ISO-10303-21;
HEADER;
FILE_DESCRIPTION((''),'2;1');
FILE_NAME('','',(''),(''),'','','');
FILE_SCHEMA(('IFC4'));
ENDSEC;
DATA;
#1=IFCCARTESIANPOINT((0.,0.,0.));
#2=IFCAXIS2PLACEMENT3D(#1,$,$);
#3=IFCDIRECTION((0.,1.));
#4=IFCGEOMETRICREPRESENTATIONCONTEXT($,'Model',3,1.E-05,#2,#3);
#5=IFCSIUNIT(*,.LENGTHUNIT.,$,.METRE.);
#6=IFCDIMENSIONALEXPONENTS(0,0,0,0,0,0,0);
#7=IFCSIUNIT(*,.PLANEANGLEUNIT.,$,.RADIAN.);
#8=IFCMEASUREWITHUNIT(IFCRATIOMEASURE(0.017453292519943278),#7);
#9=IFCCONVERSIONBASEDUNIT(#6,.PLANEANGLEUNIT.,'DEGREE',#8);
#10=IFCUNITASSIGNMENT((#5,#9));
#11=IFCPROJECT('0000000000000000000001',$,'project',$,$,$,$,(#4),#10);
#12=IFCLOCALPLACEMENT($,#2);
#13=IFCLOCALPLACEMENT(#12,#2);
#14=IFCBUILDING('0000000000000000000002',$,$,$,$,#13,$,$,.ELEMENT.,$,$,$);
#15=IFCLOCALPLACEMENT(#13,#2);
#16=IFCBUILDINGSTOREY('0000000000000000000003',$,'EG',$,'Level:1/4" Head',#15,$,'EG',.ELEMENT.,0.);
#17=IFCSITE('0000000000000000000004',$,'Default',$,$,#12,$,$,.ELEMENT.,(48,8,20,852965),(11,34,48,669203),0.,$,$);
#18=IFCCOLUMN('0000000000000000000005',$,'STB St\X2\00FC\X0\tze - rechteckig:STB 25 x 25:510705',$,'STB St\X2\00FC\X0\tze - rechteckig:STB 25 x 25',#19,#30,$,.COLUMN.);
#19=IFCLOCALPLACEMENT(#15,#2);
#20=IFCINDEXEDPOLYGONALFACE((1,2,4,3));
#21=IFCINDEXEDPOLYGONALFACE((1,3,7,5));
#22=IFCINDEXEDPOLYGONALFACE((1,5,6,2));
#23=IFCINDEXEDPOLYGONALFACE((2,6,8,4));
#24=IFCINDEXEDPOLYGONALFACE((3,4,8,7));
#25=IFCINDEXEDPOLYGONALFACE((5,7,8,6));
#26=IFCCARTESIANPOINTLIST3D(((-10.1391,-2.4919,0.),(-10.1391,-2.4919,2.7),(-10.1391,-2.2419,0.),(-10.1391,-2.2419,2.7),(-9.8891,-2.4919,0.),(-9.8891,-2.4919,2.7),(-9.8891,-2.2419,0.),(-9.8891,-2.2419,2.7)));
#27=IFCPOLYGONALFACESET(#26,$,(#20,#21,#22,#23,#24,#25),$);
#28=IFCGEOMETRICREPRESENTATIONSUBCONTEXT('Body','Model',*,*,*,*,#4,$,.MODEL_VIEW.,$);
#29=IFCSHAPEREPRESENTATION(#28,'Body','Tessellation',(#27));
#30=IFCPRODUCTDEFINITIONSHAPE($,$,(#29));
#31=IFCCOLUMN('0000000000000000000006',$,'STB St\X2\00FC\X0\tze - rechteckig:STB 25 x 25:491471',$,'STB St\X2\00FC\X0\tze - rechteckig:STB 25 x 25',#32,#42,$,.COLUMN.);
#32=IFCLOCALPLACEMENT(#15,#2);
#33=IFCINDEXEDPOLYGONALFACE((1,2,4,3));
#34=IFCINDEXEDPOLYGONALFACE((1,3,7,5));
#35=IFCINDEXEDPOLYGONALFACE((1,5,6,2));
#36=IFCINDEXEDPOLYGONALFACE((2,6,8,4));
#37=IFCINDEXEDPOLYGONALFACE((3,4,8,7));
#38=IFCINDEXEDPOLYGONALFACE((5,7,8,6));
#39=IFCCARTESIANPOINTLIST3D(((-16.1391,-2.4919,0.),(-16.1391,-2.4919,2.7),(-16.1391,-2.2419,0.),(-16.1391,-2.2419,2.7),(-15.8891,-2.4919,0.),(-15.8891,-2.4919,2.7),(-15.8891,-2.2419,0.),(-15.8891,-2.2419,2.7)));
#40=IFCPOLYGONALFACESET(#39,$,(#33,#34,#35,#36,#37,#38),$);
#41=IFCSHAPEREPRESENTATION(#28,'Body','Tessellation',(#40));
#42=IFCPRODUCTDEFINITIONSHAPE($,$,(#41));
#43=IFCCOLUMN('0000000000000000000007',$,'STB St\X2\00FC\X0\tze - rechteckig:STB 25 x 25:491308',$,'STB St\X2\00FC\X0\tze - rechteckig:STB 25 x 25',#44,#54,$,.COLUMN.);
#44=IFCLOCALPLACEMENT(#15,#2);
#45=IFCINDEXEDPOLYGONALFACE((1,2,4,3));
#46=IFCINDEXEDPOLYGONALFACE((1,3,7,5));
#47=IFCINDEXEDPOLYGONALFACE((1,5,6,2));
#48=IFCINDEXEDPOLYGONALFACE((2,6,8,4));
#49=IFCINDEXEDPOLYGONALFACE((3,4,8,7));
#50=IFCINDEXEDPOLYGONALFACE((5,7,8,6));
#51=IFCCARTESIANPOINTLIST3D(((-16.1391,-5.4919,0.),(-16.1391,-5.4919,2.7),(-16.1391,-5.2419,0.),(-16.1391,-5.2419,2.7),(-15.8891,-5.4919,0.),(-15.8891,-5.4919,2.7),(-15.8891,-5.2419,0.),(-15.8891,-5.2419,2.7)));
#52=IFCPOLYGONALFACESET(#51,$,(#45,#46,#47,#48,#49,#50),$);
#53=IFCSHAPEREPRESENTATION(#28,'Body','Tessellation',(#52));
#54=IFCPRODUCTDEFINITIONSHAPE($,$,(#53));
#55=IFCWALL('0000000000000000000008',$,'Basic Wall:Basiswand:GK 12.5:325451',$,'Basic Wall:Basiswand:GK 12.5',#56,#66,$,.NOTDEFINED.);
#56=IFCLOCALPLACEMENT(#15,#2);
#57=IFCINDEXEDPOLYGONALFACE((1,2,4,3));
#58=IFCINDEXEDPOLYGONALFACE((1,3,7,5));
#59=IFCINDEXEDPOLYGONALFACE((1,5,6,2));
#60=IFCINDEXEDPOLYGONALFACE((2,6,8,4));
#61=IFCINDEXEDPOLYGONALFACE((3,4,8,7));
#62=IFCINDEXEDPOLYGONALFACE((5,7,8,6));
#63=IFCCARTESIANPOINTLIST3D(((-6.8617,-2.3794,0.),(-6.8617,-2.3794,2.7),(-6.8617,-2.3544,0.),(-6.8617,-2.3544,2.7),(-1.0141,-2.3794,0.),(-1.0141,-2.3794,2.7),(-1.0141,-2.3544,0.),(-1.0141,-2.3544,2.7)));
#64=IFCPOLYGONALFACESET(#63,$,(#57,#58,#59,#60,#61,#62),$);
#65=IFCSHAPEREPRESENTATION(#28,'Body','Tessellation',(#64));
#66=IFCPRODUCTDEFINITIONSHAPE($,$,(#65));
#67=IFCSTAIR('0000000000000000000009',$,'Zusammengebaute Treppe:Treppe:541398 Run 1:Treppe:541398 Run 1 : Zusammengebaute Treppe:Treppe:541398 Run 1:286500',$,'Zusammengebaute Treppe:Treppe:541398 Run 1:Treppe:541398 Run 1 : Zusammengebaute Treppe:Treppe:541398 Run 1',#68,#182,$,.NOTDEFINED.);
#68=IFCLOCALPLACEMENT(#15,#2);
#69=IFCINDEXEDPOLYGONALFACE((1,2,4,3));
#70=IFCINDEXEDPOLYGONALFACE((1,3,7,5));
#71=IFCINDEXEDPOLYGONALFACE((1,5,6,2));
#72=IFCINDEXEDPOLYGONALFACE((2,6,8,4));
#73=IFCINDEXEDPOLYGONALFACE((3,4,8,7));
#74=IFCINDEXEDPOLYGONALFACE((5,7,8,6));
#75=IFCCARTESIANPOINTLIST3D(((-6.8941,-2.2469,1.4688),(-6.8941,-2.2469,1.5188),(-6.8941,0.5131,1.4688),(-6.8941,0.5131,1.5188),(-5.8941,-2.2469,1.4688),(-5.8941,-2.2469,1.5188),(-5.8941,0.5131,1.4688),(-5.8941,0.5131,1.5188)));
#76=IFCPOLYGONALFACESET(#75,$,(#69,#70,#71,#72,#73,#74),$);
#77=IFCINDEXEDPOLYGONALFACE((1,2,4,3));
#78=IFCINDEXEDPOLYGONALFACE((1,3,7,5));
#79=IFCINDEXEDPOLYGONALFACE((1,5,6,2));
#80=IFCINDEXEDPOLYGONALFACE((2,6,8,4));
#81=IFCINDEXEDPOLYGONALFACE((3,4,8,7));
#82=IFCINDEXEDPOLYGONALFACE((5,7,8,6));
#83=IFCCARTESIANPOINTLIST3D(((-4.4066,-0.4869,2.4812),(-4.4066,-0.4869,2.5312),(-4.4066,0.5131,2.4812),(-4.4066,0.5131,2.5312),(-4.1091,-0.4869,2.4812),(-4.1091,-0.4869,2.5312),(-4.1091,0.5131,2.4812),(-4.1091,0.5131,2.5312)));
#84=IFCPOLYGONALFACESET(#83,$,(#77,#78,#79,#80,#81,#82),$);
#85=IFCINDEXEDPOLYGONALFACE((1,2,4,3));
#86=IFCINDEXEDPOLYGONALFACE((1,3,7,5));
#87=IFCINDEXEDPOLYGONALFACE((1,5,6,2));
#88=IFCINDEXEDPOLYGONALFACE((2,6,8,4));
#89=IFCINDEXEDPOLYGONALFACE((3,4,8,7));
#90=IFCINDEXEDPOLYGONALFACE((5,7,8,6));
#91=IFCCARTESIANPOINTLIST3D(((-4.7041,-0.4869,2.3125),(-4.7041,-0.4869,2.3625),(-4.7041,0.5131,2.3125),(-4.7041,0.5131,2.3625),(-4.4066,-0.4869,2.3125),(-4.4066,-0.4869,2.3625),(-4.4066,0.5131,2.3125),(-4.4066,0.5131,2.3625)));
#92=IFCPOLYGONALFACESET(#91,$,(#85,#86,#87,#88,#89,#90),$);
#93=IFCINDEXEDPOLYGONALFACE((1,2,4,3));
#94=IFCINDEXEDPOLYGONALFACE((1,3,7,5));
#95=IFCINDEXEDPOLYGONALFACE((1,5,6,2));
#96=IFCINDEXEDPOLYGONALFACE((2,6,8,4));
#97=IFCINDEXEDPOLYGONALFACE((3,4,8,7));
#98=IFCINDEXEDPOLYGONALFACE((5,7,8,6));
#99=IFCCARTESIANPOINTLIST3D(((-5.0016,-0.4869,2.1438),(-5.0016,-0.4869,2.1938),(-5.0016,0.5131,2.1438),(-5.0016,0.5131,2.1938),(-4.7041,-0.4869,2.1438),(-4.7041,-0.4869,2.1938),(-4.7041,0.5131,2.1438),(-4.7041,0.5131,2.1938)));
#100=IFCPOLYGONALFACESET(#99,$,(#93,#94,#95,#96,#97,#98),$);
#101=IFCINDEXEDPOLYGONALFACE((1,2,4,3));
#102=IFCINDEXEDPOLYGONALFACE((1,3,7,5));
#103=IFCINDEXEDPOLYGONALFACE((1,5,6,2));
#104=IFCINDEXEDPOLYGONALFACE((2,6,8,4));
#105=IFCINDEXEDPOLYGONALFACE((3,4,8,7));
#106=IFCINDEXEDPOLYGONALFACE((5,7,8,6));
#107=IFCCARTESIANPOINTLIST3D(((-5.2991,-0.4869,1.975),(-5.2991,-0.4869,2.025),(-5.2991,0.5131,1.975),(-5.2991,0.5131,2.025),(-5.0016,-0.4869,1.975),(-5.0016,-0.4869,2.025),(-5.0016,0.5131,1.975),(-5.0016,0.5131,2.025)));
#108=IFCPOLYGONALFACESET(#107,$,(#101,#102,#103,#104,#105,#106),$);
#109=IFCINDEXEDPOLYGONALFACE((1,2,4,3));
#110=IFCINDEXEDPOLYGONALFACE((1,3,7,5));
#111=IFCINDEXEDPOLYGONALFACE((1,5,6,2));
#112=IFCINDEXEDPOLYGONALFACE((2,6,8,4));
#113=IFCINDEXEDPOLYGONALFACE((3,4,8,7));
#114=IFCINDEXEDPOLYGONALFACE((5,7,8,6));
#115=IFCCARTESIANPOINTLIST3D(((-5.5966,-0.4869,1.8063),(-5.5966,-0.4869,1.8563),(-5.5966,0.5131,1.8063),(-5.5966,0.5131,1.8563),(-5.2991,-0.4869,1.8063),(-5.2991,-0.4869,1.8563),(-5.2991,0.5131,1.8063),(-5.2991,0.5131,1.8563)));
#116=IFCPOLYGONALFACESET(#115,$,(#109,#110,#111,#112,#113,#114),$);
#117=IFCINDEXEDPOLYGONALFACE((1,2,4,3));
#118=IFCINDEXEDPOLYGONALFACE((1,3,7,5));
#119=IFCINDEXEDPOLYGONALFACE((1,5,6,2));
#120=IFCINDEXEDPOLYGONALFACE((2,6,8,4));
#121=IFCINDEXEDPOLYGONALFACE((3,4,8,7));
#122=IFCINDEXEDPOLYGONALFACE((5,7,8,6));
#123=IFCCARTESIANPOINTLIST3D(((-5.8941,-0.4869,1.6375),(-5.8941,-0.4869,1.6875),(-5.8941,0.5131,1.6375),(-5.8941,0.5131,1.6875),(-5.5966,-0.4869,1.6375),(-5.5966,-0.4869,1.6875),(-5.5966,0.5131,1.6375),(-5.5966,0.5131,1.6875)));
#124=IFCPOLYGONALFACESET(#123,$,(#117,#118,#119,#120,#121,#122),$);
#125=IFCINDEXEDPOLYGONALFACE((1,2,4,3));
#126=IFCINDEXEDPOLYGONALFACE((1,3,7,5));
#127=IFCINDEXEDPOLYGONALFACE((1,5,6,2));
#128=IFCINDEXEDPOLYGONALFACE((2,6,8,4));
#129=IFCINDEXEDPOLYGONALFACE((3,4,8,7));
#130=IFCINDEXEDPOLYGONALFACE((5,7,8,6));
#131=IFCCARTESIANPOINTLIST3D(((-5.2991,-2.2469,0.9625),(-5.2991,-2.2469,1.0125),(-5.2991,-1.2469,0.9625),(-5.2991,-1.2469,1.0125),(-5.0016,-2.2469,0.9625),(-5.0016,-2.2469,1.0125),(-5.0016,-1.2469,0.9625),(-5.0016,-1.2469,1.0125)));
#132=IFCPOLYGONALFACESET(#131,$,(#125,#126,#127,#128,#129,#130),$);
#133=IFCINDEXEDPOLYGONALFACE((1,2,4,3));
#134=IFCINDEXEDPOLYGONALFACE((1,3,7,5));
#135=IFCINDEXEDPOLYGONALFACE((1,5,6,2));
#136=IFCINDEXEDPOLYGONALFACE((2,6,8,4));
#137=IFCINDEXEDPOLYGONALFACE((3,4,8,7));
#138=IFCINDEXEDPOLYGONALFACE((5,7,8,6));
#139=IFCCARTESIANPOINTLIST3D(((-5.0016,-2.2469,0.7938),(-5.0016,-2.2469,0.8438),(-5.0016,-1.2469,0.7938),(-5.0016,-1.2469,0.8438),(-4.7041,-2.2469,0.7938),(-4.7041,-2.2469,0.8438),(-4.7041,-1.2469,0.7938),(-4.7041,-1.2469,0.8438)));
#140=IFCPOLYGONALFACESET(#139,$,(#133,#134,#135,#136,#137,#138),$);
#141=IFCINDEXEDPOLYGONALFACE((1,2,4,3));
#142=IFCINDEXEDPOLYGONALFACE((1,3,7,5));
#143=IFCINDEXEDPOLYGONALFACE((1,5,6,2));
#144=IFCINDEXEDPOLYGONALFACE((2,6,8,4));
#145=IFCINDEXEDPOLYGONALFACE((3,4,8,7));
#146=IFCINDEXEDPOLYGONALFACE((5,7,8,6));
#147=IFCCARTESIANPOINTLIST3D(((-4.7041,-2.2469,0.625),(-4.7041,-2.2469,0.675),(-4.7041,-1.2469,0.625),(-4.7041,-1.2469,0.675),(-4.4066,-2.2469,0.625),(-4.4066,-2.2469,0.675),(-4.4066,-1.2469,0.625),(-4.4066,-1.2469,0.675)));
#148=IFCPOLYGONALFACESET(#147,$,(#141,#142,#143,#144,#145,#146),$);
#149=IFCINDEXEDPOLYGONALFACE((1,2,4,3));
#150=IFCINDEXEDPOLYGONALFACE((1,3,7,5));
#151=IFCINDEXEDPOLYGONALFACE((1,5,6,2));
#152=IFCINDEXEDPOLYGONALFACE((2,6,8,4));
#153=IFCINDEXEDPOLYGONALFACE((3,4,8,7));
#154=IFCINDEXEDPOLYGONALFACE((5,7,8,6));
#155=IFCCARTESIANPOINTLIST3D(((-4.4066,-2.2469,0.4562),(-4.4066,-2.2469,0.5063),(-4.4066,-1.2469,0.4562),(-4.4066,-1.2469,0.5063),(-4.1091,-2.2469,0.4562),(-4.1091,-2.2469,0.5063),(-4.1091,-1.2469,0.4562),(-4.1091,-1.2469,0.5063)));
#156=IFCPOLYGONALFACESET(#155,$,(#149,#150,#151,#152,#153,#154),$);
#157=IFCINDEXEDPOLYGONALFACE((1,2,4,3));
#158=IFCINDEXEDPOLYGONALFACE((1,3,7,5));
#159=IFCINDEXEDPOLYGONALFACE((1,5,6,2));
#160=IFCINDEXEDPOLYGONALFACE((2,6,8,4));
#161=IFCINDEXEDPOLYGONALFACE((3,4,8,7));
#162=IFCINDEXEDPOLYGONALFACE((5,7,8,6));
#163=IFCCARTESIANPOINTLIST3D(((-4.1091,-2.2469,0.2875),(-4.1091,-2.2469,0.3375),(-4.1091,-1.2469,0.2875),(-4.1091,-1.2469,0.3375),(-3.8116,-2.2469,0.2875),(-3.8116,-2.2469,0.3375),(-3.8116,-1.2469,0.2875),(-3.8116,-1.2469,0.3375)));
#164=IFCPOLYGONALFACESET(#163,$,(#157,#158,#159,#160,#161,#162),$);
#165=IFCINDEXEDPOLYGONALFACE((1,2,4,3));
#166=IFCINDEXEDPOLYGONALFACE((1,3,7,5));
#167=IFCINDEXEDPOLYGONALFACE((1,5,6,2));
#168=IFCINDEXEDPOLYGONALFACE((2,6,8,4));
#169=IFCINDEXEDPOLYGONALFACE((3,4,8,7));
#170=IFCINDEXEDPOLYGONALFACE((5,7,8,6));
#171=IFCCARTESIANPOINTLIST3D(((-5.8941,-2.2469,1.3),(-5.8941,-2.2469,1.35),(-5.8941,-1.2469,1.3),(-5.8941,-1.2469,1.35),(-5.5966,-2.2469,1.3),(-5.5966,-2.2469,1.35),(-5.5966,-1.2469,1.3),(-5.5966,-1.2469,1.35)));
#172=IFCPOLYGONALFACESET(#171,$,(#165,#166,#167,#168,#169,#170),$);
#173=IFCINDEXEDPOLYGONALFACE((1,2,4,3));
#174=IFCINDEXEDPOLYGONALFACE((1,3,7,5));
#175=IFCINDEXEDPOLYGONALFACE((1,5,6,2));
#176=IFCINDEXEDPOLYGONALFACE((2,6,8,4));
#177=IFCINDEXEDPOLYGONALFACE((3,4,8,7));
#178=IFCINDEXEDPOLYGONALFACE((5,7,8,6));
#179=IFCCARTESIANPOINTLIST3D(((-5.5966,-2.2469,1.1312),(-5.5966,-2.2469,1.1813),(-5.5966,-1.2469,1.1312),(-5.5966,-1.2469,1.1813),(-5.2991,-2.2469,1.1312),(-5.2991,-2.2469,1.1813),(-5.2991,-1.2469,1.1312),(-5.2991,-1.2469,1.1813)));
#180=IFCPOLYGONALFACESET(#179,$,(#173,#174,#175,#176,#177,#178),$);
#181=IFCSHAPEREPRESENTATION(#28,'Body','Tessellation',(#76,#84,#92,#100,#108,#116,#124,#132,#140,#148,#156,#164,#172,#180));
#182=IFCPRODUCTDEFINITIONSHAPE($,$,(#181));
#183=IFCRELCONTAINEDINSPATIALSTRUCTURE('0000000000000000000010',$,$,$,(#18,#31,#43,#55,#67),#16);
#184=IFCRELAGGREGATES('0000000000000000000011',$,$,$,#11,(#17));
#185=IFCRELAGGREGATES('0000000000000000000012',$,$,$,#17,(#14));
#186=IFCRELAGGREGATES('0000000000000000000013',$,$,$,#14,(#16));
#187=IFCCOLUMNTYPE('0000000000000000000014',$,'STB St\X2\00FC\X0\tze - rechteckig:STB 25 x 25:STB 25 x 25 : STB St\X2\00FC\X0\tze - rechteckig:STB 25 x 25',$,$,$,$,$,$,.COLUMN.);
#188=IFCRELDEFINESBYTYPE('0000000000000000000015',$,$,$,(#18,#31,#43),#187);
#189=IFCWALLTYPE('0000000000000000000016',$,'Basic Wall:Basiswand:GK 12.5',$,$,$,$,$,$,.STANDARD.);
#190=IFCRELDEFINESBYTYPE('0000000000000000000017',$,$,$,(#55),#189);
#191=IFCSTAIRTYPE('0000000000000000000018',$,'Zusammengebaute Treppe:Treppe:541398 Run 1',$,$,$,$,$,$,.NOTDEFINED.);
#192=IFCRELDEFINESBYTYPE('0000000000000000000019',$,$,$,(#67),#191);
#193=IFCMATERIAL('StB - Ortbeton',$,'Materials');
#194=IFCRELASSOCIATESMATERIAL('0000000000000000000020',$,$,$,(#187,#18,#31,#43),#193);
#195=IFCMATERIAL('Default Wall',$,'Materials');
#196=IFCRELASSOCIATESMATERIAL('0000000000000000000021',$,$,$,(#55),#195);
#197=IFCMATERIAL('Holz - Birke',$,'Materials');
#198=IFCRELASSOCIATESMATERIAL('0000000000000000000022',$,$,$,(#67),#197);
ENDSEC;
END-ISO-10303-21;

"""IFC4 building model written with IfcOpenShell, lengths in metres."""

from ifc_helpers import new_model, entity, si_unit, converted_unit, direction, frame, origin, place, context, subcontext, project, spatial, indexed_curve, outline, extrude, source, transform, mapped, material, type_object, type_shapes, element, save


model = new_model("IFC4")

# Units and contexts
model_context = context("Model", 3, precision=1e-05, world=origin(), true_north=direction((0.0, 1.0)))
body_context = subcontext(model_context, "Body", "Model", "MODEL_VIEW")
ifc_project = project(units=[si_unit("LENGTHUNIT", "METRE"), converted_unit("PLANEANGLEUNIT", "DEGREE", entity("IfcRatioMeasure", 0.017453292519943278), si_unit("PLANEANGLEUNIT", "RADIAN"), dimensions=[0, 0, 0, 0, 0, 0, 0])], contexts=[model_context])

# Site, building, storey
site_placement = place(None, origin())
site = spatial("IfcSite", under=ifc_project, at=site_placement, Name="Default", CompositionType="ELEMENT", RefLatitude=(48, 8, 20, 852965), RefLongitude=(11, 34, 48, 669203), RefElevation=0.0)
building_placement = place(site_placement, origin())
building = spatial("IfcBuilding", under=site, at=building_placement, CompositionType="ELEMENT")
storey_placement = place(building_placement, origin())
storey = spatial("IfcBuildingStorey", under=building, at=storey_placement, Name="EG", ObjectType="Level:1/4\" Head", LongName="EG", CompositionType="ELEMENT", Elevation=0.0)

# Columns
ifc_material_1 = material(Name="StB - Ortbeton", Category="Materials")
column_type = type_object("IfcColumnType", Name="STB Stütze - rechteckig:STB 25 x 25:STB 25 x 25 : STB Stütze - rechteckig:STB 25 x 25", PredefinedType="COLUMN", material=ifc_material_1)
shared_shape_1 = source(origin(), body_context, "Body", "SweptSolid", [
    extrude(outline(indexed_curve([(-0.125, -0.125), (0.125, -0.125), (0.125, 0.125), (-0.125, 0.125), (-0.125, -0.125)], self_intersect=False)), frame((0.0, 0.0, 0.0), z_axis=(0.0, 0.0, 1.0), x_axis=(0.0, -1.0, 0.0)), (0.0, 0.0, 1.0), 2.7),
])
type_shapes(column_type, [shared_shape_1])
for number, where, name in (
    (1, (-10.0141, -2.3669, 0.0), "STB Stütze - rechteckig:STB 25 x 25:510705"),
    (2, (-16.0141, -2.3669, 0.0), "STB Stütze - rechteckig:STB 25 x 25:491471"),
    (3, (-16.0141, -5.3669, 0.0), "STB Stütze - rechteckig:STB 25 x 25:491308"),
):
    element("IfcColumn", number, at=place(storey_placement, frame(where)), inside=storey, type_object=column_type, material=ifc_material_1, Name=name, ObjectType="STB Stütze - rechteckig:STB 25 x 25", PredefinedType="COLUMN", context=body_context, shape_type="MappedRepresentation", body=[
        mapped(shared_shape_1, transform((0.0, 0.0, 0.0), scale=1.0)),
    ])

# Wall
ifc_material_2 = material(Name="Default Wall", Category="Materials")
wall_type_1 = type_object("IfcWallType", Name="Basic Wall:Basiswand:GK 12.5", PredefinedType="STANDARD")
wall_1_placement = place(storey_placement, frame((-6.8617, -2.3669, 0.0)))
element("IfcWall", 4, at=wall_1_placement, inside=storey, type_object=wall_type_1, material=ifc_material_2, Name="Basic Wall:Basiswand:GK 12.5:325451", ObjectType="Basic Wall:Basiswand:GK 12.5", PredefinedType="NOTDEFINED", context=body_context, shape_type="SweptSolid", body=[
    extrude(outline(indexed_curve([(5.8476, 0.0125), (0.0, 0.0125), (0.0, -0.0125), (5.8476, -0.0125), (5.8476, 0.0125)], self_intersect=False)), origin(), (0.0, 0.0, 1.0), 2.7),
])

# Stair
ifc_material_3 = material(Name="Holz - Birke", Category="Materials")
stair_type_1 = type_object("IfcStairType", Name="Zusammengebaute Treppe:Treppe:541398 Run 1", PredefinedType="NOTDEFINED")
stair_1_placement = place(storey_placement, origin())
element("IfcStair", 5, at=stair_1_placement, inside=storey, type_object=stair_type_1, material=ifc_material_3, Name="Zusammengebaute Treppe:Treppe:541398 Run 1:Treppe:541398 Run 1 : Zusammengebaute Treppe:Treppe:541398 Run 1:286500", ObjectType="Zusammengebaute Treppe:Treppe:541398 Run 1:Treppe:541398 Run 1 : Zusammengebaute Treppe:Treppe:541398 Run 1", PredefinedType="NOTDEFINED", context=body_context, shape_type="SweptSolid", body=[
    extrude(outline(indexed_curve([(-0.5, -1.38), (0.5, -1.38), (0.5, 1.38), (-0.5, 1.38), (-0.5, -1.38)], self_intersect=False)), frame((-6.3941, -0.8669, 1.4688), z_axis=(0.0, 0.0, 1.0), x_axis=(-1.0, 0.0, 0.0)), (0.0, 0.0, 1.0), 0.05),
    extrude(outline(indexed_curve([(-0.5, -0.1488), (0.5, -0.1488), (0.5, 0.1488), (-0.5, 0.1488), (-0.5, -0.1488)], self_intersect=False)), frame((-4.2578, 0.0131, 2.4813), z_axis=(0.0, 0.0, 1.0), x_axis=(0.0, -1.0, 0.0)), (0.0, 0.0, 1.0), 0.05),
    extrude(outline(indexed_curve([(-0.5, -0.1488), (0.5, -0.1488), (0.5, 0.1488), (-0.5, 0.1488), (-0.5, -0.1488)], self_intersect=False)), frame((-4.5553, 0.0131, 2.3125), z_axis=(0.0, 0.0, 1.0), x_axis=(0.0, -1.0, 0.0)), (0.0, 0.0, 1.0), 0.05),
    extrude(outline(indexed_curve([(-0.5, -0.1488), (0.5, -0.1488), (0.5, 0.1488), (-0.5, 0.1488), (-0.5, -0.1488)], self_intersect=False)), frame((-4.8528, 0.0131, 2.1438), z_axis=(0.0, 0.0, 1.0), x_axis=(0.0, -1.0, 0.0)), (0.0, 0.0, 1.0), 0.05),
    extrude(outline(indexed_curve([(-0.5, -0.1487), (0.5, -0.1487), (0.5, 0.1488), (-0.5, 0.1488), (-0.5, -0.1487)], self_intersect=False)), frame((-5.1503, 0.0131, 1.975), z_axis=(0.0, 0.0, 1.0), x_axis=(0.0, -1.0, 0.0)), (0.0, 0.0, 1.0), 0.05),
    extrude(outline(indexed_curve([(-0.5, -0.1487), (0.5, -0.1487), (0.5, 0.1488), (-0.5, 0.1488), (-0.5, -0.1487)], self_intersect=False)), frame((-5.4478, 0.0131, 1.8063), z_axis=(0.0, 0.0, 1.0), x_axis=(0.0, -1.0, 0.0)), (0.0, 0.0, 1.0), 0.05),
    extrude(outline(indexed_curve([(-0.5, -0.1487), (0.5, -0.1487), (0.5, 0.1487), (-0.5, 0.1487), (-0.5, -0.1487)], self_intersect=False)), frame((-5.7453, 0.0131, 1.6375), z_axis=(0.0, 0.0, 1.0), x_axis=(0.0, -1.0, 0.0)), (0.0, 0.0, 1.0), 0.05),
    extrude(outline(indexed_curve([(-0.5, -0.1487), (0.5, -0.1487), (0.5, 0.1487), (-0.5, 0.1487), (-0.5, -0.1487)], self_intersect=False)), frame((-5.1503, -1.7469, 0.9625), z_axis=(0.0, 0.0, 1.0), x_axis=(0.0, 1.0, 0.0)), (0.0, 0.0, 1.0), 0.05),
    extrude(outline(indexed_curve([(-0.5, -0.1487), (0.5, -0.1487), (0.5, 0.1487), (-0.5, 0.1487), (-0.5, -0.1487)], self_intersect=False)), frame((-4.8528, -1.7469, 0.7938), z_axis=(0.0, 0.0, 1.0), x_axis=(0.0, 1.0, 0.0)), (0.0, 0.0, 1.0), 0.05),
    extrude(outline(indexed_curve([(-0.5, -0.1487), (0.5, -0.1487), (0.5, 0.1488), (-0.5, 0.1488), (-0.5, -0.1487)], self_intersect=False)), frame((-4.5553, -1.7469, 0.625), z_axis=(0.0, 0.0, 1.0), x_axis=(0.0, 1.0, 0.0)), (0.0, 0.0, 1.0), 0.05),
    extrude(outline(indexed_curve([(-0.5, -0.1487), (0.5, -0.1487), (0.5, 0.1488), (-0.5, 0.1488), (-0.5, -0.1487)], self_intersect=False)), frame((-4.2578, -1.7469, 0.4563), z_axis=(0.0, 0.0, 1.0), x_axis=(0.0, 1.0, 0.0)), (0.0, 0.0, 1.0), 0.05),
    extrude(outline(indexed_curve([(-0.5, -0.1487), (0.5, -0.1487), (0.5, 0.1487), (-0.5, 0.1487), (-0.5, -0.1487)], self_intersect=False)), frame((-3.9603, -1.7469, 0.2875), z_axis=(0.0, 0.0, 1.0), x_axis=(0.0, 1.0, 0.0)), (0.0, 0.0, 1.0), 0.05),
    extrude(outline(indexed_curve([(-0.5, -0.1487), (0.5, -0.1487), (0.5, 0.1487), (-0.5, 0.1487), (-0.5, -0.1487)], self_intersect=False)), frame((-5.7453, -1.7469, 1.3), z_axis=(0.0, 0.0, 1.0), x_axis=(0.0, 1.0, 0.0)), (0.0, 0.0, 1.0), 0.05),
    extrude(outline(indexed_curve([(-0.5, -0.1487), (0.5, -0.1487), (0.5, 0.1487), (-0.5, 0.1487), (-0.5, -0.1487)], self_intersect=False)), frame((-5.4478, -1.7469, 1.1313), z_axis=(0.0, 0.0, 1.0), x_axis=(0.0, 1.0, 0.0)), (0.0, 0.0, 1.0), 0.05),
])

save(model, "model.ifc")
